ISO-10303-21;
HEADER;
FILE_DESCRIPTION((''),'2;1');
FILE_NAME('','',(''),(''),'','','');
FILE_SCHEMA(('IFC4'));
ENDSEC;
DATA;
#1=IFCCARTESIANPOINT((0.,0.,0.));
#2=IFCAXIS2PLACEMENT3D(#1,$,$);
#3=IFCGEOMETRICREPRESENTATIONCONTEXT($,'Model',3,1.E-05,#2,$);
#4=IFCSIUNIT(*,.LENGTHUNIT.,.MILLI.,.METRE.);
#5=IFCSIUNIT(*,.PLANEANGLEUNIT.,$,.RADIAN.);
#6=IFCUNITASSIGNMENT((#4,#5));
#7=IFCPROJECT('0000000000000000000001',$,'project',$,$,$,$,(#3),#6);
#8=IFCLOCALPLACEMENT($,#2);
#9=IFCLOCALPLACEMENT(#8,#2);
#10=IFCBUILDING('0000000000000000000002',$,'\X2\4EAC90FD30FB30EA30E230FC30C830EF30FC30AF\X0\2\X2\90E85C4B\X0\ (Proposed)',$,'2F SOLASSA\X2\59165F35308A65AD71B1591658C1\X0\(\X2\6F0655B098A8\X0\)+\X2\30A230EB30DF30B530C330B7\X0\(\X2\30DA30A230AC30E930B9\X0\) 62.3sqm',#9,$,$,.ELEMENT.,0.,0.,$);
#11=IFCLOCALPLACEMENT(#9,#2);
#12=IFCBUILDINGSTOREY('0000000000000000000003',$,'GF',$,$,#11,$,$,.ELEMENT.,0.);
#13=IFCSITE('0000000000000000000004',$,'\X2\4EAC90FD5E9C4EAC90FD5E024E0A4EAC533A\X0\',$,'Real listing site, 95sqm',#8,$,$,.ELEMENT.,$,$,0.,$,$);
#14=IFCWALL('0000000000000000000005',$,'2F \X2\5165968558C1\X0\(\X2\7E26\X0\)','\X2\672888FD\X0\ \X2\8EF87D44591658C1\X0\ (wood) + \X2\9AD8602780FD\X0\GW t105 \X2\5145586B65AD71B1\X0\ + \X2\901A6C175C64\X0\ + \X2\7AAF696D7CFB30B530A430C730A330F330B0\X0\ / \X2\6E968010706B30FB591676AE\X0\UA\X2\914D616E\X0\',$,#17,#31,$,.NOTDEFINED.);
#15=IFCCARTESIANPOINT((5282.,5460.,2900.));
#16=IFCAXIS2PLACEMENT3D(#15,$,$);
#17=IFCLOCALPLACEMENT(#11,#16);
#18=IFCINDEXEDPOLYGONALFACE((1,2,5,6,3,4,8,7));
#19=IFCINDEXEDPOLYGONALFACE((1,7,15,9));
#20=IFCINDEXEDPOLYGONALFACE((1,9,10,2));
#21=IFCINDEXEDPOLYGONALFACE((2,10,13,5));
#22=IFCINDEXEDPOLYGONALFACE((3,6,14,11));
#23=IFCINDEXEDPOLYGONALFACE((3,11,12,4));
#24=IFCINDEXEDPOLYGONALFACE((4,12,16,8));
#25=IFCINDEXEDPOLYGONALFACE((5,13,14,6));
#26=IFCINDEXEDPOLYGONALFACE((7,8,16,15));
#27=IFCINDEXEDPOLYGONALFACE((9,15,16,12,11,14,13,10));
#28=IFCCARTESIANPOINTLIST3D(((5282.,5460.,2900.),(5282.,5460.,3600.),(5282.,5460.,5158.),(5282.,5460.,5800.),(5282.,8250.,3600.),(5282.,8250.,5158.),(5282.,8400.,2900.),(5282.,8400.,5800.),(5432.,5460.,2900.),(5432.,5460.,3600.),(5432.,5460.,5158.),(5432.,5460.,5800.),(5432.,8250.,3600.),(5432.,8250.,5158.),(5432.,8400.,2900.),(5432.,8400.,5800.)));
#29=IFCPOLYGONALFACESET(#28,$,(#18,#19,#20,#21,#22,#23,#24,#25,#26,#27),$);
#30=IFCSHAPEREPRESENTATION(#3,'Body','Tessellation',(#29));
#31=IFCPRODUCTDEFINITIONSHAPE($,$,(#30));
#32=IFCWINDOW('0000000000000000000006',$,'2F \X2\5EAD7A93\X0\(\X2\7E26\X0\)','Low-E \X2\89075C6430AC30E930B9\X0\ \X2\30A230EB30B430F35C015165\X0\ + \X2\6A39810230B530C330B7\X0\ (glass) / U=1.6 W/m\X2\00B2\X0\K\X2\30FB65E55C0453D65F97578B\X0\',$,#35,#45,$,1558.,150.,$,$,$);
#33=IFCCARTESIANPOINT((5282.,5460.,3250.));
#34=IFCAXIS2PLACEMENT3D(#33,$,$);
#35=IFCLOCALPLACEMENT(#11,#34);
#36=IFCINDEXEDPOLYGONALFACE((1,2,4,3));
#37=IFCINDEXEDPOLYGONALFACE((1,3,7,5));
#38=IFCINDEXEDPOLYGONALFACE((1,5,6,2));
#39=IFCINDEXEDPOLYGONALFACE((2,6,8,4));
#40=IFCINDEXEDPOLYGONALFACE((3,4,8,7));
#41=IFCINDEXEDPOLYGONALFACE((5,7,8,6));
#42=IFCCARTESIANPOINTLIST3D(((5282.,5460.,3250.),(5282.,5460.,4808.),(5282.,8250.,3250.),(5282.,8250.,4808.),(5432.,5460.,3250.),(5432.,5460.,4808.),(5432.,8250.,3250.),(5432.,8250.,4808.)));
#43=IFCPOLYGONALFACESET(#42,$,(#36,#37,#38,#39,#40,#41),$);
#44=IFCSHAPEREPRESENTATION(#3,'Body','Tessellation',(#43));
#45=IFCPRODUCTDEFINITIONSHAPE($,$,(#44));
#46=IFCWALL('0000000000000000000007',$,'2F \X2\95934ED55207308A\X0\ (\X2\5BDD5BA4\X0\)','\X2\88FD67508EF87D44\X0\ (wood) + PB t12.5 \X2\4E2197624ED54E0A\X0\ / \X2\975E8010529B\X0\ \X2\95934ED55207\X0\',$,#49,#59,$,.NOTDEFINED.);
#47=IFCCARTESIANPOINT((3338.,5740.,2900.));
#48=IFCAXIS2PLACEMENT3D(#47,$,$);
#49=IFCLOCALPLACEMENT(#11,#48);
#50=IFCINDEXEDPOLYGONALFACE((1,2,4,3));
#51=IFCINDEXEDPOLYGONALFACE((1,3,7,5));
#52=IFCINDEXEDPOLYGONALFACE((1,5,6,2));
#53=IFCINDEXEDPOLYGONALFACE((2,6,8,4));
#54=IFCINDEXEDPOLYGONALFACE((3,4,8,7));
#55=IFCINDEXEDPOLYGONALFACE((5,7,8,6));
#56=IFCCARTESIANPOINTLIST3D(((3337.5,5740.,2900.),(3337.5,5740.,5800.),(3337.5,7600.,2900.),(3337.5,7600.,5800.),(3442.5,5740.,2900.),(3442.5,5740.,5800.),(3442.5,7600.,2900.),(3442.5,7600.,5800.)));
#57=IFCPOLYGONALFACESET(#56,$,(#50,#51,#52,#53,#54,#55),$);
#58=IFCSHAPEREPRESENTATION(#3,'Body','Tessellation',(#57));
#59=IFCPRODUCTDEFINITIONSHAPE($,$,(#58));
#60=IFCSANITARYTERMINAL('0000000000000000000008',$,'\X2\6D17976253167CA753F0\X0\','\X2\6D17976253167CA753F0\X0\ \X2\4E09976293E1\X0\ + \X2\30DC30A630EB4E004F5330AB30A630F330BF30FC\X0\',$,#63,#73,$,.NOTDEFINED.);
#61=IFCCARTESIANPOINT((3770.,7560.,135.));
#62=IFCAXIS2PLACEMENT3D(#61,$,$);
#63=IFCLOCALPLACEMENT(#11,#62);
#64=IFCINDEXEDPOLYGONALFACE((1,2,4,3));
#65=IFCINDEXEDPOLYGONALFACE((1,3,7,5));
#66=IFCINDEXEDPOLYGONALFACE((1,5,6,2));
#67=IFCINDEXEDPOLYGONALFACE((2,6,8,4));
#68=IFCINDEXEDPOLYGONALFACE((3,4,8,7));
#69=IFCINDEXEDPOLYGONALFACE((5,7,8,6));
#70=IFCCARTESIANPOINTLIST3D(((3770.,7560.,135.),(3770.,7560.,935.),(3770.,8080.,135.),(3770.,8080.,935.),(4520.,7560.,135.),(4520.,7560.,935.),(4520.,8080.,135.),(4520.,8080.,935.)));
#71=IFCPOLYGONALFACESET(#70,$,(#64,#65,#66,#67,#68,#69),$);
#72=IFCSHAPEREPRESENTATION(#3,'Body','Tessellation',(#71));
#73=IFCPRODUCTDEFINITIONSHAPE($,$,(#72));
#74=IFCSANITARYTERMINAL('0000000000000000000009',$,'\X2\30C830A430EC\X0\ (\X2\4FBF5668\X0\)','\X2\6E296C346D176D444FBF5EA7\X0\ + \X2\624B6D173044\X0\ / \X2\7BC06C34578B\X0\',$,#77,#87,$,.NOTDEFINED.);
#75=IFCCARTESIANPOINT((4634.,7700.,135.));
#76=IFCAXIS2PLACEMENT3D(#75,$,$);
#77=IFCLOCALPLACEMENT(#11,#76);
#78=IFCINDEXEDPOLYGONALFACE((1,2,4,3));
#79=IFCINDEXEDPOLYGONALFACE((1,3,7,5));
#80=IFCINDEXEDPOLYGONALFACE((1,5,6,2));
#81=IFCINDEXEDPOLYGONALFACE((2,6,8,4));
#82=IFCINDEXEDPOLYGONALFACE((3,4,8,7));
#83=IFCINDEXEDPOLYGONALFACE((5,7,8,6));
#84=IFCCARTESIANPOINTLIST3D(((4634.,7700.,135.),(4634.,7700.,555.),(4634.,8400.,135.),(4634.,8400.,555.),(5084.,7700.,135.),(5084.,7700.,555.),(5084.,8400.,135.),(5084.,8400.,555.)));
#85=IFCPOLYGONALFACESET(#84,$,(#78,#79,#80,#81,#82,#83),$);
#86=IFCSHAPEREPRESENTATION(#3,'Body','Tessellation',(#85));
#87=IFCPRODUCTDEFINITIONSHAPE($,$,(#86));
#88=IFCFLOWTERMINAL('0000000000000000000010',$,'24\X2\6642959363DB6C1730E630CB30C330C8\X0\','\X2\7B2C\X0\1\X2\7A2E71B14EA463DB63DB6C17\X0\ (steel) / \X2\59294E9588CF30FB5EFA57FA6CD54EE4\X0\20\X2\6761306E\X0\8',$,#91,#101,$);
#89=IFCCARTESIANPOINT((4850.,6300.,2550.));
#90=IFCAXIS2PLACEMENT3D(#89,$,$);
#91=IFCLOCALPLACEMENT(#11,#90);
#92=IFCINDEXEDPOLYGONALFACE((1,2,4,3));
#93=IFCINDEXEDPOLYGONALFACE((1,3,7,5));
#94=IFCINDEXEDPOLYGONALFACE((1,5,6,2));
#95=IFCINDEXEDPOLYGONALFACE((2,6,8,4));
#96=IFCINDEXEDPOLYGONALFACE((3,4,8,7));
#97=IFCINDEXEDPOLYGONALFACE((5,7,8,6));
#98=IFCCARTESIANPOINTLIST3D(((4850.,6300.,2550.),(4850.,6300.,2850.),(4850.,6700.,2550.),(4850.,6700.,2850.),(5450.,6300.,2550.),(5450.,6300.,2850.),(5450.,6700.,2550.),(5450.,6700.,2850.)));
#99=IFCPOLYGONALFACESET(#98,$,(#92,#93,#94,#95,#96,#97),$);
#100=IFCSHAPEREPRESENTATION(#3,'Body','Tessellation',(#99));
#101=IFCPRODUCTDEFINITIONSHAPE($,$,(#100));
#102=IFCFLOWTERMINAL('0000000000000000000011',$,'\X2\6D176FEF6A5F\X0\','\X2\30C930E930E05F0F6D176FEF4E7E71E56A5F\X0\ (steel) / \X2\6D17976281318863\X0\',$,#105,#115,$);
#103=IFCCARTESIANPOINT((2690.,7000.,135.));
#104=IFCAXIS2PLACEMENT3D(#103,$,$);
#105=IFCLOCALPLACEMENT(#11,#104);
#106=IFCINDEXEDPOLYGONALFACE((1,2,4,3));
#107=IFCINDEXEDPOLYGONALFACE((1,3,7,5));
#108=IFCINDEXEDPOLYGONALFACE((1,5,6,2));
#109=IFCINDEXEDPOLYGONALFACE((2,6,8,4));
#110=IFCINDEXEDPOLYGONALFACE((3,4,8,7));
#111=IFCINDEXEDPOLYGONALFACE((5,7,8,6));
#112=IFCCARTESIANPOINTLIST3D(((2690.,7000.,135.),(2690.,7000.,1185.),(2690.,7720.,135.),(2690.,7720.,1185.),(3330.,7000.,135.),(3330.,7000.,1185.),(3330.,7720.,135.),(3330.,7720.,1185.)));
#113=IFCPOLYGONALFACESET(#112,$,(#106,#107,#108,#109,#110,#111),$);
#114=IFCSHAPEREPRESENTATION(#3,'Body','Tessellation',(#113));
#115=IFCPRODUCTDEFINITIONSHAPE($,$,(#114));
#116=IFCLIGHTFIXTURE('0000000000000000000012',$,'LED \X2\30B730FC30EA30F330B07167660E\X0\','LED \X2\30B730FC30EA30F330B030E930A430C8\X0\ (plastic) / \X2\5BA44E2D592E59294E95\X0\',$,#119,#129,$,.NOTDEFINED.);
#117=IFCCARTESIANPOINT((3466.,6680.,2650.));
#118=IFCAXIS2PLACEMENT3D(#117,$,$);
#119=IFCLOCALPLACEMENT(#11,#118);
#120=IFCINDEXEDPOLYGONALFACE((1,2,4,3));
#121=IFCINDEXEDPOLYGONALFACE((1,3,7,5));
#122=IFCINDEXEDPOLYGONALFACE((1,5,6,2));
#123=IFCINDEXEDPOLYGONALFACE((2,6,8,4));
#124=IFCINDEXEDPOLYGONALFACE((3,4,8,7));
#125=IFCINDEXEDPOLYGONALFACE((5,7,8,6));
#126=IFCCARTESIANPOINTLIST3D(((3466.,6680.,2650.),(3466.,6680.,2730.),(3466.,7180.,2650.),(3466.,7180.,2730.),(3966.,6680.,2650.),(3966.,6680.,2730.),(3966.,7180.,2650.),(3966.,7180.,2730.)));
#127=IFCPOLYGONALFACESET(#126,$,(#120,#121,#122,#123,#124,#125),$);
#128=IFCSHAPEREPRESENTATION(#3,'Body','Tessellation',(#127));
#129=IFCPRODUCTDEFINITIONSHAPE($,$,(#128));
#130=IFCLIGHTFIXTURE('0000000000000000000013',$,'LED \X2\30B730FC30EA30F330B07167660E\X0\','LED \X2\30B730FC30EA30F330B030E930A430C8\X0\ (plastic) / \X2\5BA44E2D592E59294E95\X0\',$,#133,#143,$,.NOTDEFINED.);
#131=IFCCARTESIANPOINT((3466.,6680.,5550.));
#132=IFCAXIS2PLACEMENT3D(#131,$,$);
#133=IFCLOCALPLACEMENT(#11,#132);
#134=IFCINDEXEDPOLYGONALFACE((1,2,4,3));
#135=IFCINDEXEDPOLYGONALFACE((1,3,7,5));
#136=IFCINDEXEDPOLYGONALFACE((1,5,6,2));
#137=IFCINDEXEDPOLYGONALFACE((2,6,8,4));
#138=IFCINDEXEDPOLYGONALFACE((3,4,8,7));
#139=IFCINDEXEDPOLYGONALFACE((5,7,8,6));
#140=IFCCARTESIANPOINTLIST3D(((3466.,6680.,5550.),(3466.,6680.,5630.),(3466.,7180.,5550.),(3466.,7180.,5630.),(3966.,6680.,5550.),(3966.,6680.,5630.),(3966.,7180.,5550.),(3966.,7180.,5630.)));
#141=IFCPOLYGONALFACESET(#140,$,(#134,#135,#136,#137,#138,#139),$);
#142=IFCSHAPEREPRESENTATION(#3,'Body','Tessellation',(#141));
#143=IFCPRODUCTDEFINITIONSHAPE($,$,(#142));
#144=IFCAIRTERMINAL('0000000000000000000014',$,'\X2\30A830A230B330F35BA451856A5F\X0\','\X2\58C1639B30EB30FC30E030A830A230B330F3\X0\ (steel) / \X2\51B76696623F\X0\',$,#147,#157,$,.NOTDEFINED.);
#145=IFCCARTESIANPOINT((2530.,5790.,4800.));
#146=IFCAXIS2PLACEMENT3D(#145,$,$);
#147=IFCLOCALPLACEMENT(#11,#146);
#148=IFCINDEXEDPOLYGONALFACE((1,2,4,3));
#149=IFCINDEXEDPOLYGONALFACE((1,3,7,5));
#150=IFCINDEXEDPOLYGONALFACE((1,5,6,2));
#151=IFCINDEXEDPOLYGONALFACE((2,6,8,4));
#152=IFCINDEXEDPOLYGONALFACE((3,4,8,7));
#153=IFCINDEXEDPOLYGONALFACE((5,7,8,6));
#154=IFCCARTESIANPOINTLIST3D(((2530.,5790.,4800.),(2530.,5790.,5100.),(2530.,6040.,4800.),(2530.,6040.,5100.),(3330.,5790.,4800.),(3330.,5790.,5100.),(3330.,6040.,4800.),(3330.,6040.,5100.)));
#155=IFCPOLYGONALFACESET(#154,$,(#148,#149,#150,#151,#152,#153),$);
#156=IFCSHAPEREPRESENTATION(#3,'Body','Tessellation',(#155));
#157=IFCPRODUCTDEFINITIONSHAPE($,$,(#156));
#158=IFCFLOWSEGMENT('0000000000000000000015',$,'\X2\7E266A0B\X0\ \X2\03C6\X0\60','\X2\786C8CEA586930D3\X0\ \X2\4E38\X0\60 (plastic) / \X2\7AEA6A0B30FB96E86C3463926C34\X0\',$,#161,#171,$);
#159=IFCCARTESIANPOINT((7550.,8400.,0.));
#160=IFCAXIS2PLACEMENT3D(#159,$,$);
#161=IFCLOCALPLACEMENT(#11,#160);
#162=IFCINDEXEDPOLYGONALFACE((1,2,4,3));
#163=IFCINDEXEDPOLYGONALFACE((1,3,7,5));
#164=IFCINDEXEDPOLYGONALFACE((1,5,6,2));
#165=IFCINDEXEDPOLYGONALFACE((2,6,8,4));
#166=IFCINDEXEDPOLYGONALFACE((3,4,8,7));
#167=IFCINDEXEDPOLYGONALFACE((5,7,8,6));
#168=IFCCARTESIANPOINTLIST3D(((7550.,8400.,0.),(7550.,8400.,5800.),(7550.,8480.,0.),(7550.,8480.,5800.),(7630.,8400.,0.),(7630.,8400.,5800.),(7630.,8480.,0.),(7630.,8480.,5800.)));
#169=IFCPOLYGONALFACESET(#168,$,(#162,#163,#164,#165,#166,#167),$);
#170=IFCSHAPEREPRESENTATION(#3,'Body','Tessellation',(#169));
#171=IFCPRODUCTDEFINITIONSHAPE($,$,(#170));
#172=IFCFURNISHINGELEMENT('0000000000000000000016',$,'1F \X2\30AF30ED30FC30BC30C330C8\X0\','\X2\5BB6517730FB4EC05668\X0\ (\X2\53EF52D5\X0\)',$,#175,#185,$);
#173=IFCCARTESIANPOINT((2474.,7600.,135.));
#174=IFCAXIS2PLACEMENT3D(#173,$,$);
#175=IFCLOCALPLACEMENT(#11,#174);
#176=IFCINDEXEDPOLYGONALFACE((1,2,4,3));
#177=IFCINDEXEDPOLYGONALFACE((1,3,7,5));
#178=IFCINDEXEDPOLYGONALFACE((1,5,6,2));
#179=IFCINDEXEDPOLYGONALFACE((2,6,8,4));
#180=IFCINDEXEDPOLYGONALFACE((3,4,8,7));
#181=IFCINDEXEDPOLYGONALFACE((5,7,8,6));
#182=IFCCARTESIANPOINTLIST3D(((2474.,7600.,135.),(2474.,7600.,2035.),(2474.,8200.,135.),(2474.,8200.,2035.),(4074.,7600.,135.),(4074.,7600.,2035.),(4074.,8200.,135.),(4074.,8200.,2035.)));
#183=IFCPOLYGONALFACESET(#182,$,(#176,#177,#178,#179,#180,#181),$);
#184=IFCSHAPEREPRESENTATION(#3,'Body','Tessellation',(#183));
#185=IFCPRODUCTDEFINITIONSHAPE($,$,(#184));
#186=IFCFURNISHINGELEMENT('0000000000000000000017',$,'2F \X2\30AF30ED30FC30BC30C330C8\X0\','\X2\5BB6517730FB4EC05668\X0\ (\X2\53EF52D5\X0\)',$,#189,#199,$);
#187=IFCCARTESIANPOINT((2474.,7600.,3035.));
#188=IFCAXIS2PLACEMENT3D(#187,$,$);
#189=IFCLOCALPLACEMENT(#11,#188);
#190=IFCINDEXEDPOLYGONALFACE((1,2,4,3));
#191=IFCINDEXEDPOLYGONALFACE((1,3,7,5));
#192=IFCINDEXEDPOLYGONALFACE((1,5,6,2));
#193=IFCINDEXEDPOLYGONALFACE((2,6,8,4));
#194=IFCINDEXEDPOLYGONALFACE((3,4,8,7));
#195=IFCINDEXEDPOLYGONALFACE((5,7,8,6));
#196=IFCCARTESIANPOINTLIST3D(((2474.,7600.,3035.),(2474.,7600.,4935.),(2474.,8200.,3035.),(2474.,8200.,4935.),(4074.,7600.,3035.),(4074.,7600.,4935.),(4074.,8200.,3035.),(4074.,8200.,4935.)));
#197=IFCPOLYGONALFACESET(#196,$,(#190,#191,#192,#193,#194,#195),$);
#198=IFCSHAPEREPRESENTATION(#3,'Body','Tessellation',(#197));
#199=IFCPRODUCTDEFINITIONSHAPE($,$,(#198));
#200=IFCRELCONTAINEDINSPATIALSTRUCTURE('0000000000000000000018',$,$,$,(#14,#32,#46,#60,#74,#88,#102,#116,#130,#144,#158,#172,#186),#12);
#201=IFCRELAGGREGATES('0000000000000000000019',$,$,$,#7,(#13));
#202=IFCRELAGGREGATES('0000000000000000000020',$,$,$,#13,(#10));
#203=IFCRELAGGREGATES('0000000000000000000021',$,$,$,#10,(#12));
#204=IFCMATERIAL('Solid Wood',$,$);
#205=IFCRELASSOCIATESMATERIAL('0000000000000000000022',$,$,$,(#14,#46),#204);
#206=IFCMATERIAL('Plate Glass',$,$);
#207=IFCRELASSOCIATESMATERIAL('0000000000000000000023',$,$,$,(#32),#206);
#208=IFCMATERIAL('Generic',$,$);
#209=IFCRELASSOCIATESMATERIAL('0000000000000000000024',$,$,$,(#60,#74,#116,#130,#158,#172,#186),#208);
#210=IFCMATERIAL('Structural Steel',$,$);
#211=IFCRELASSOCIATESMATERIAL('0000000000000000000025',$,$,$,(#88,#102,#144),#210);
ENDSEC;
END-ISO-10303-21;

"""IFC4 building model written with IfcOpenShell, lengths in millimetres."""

from ifc_helpers import new_model, si_unit, frame, frame_2d, origin, place, context, project, spatial, rectangle, extrude, material, element, fill, save


model = new_model("IFC4")

# Units and contexts
model_context = context("Model", 3, precision=1e-05, world=origin())
ifc_project = project(units=[si_unit("LENGTHUNIT", "METRE", prefix="MILLI"), si_unit("PLANEANGLEUNIT", "RADIAN")], contexts=[model_context])

# Site, building, storey
site_placement = place(None, origin())
site = spatial("IfcSite", under=ifc_project, at=site_placement, Name="京都府京都市上京区", ObjectType="Real listing site, 95sqm", CompositionType="ELEMENT", RefElevation=0.0)
building_placement = place(site_placement, origin())
building = spatial("IfcBuilding", under=site, at=building_placement, Name="京都・リモートワーク2部屋 (Proposed)", ObjectType="2F SOLASSA外張り断熱外壁(漆喰風)+アルミサッシ(ペアガラス) 62.3sqm", CompositionType="ELEMENT", ElevationOfRefHeight=0.0, ElevationOfTerrain=0.0)
storey_placement = place(building_placement, origin())
storey = spatial("IfcBuildingStorey", under=building, at=storey_placement, Name="GF", CompositionType="ELEMENT", Elevation=0.0)

# Shared definitions
ifc_material_1 = material(Name="Solid Wood")

# Shared definitions
ifc_material_2 = material(Name="Plate Glass")

# Wall, opening, window
wall_1_placement = place(storey_placement, frame((5282.0, 5460.0, 2900.0)))
wall_1 = element("IfcWall", 1, at=wall_1_placement, inside=storey, material=ifc_material_1, Name="2F 入隅壁(縦)", Description="木製 軸組外壁 (wood) + 高性能GW t105 充填断熱 + 通気層 + 窯業系サイディング / 準耐火・外皮UA配慮", PredefinedType="NOTDEFINED", context=model_context, shape_type="SweptSolid", body=[
    extrude(rectangle(XDim=150.0, YDim=2940.0, at=frame_2d((75.0, 1470.0))), frame((5282.0, 5460.0, 2900.0)), (0.0, 0.0, 1.0), 2900.0),
])
opening_1_placement = place(storey_placement, frame((5282.0, 5460.0, 3250.0)))
opening_1 = element("IfcOpeningElement", 2, at=opening_1_placement, cuts=wall_1, PredefinedType="NOTDEFINED", context=model_context, shape_type="SweptSolid", body=[
    extrude(rectangle(XDim=150.0, YDim=2790.0, at=frame_2d((75.0, 1395.0))), frame((5282.0, 5460.0, 3250.0)), (0.0, 0.0, 1.0), 1558.0),
])
window_1_placement = place(storey_placement, frame((5282.0, 5460.0, 3250.0)))
window_1 = element("IfcWindow", 3, at=window_1_placement, inside=storey, material=ifc_material_2, Name="2F 庭窓(縦)", Description="Low-E 複層ガラス アルゴン封入 + 樹脂サッシ (glass) / U=1.6 W/m²K・日射取得型", OverallHeight=1558.0, OverallWidth=150.0, context=model_context, shape_type="SweptSolid", body=[
    extrude(rectangle(XDim=150.0, YDim=2790.0, at=frame_2d((75.0, 1395.0))), frame((5282.0, 5460.0, 3250.0)), (0.0, 0.0, 1.0), 1558.0),
])
fill(opening_1, window_1)

# Wall
wall_2_placement = place(storey_placement, frame((3338.0, 5740.0, 2900.0)))
element("IfcWall", 4, at=wall_2_placement, inside=storey, material=ifc_material_1, Name="2F 間仕切り (寝室)", Description="製材軸組 (wood) + PB t12.5 両面仕上 / 非耐力 間仕切", PredefinedType="NOTDEFINED", context=model_context, shape_type="SweptSolid", body=[
    extrude(rectangle(XDim=105.0, YDim=1860.0, at=frame_2d((52.0, 930.0))), frame((3338.0, 5740.0, 2900.0)), (0.0, 0.0, 1.0), 2900.0),
])

# Sanitary terminals
ifc_material_3 = material(Name="Generic")
sanitary_terminal_1_placement = place(storey_placement, frame((3770.0, 7560.0, 135.0)))
element("IfcSanitaryTerminal", 5, at=sanitary_terminal_1_placement, inside=storey, material=ifc_material_3, Name="洗面化粧台", Description="洗面化粧台 三面鏡 + ボウル一体カウンター", PredefinedType="NOTDEFINED", context=model_context, shape_type="SweptSolid", body=[
    extrude(rectangle(XDim=750.0, YDim=520.0, at=frame_2d((375.0, 260.0))), frame((3770.0, 7560.0, 135.0)), (0.0, 0.0, 1.0), 800.0),
])
sanitary_terminal_2_placement = place(storey_placement, frame((4634.0, 7700.0, 135.0)))
element("IfcSanitaryTerminal", 6, at=sanitary_terminal_2_placement, inside=storey, material=ifc_material_3, Name="トイレ (便器)", Description="温水洗浄便座 + 手洗い / 節水型", PredefinedType="NOTDEFINED", context=model_context, shape_type="SweptSolid", body=[
    extrude(rectangle(XDim=450.0, YDim=700.0, at=frame_2d((225.0, 350.0))), frame((4634.0, 7700.0, 135.0)), (0.0, 0.0, 1.0), 420.0),
])

# Flow terminals
ifc_material_4 = material(Name="Structural Steel")
flow_terminal_1_placement = place(storey_placement, frame((4850.0, 6300.0, 2550.0)))
element("IfcFlowTerminal", 7, at=flow_terminal_1_placement, inside=storey, material=ifc_material_4, Name="24時間換気ユニット", Description="第1種熱交換換気 (steel) / 天井裏・建基法令20条の8", context=model_context, shape_type="SweptSolid", body=[
    extrude(rectangle(XDim=600.0, YDim=400.0, at=frame_2d((300.0, 200.0))), frame((4850.0, 6300.0, 2550.0)), (0.0, 0.0, 1.0), 300.0),
])
flow_terminal_2_placement = place(storey_placement, frame((2690.0, 7000.0, 135.0)))
element("IfcFlowTerminal", 8, at=flow_terminal_2_placement, inside=storey, material=ifc_material_4, Name="洗濯機", Description="ドラム式洗濯乾燥機 (steel) / 洗面脱衣", context=model_context, shape_type="SweptSolid", body=[
    extrude(rectangle(XDim=640.0, YDim=720.0, at=frame_2d((320.0, 360.0))), frame((2690.0, 7000.0, 135.0)), (0.0, 0.0, 1.0), 1050.0),
])

# Light fixtures
light_fixture_1_placement = place(storey_placement, frame((3466.0, 6680.0, 2650.0)))
element("IfcLightFixture", 9, at=light_fixture_1_placement, inside=storey, material=ifc_material_3, Name="LED シーリング照明", Description="LED シーリングライト (plastic) / 室中央天井", PredefinedType="NOTDEFINED", context=model_context, shape_type="SweptSolid", body=[
    extrude(rectangle(XDim=500.0, YDim=500.0, at=frame_2d((250.0, 250.0))), frame((3466.0, 6680.0, 2650.0)), (0.0, 0.0, 1.0), 80.0),
])
light_fixture_2_placement = place(storey_placement, frame((3466.0, 6680.0, 5550.0)))
element("IfcLightFixture", 10, at=light_fixture_2_placement, inside=storey, material=ifc_material_3, Name="LED シーリング照明", Description="LED シーリングライト (plastic) / 室中央天井", PredefinedType="NOTDEFINED", context=model_context, shape_type="SweptSolid", body=[
    extrude(rectangle(XDim=500.0, YDim=500.0, at=frame_2d((250.0, 250.0))), frame((3466.0, 6680.0, 5550.0)), (0.0, 0.0, 1.0), 80.0),
])

# Air terminal
air_terminal_placement = place(storey_placement, frame((2530.0, 5790.0, 4800.0)))
element("IfcAirTerminal", 11, at=air_terminal_placement, inside=storey, material=ifc_material_4, Name="エアコン室内機", Description="壁掛ルームエアコン (steel) / 冷暖房", PredefinedType="NOTDEFINED", context=model_context, shape_type="SweptSolid", body=[
    extrude(rectangle(XDim=800.0, YDim=250.0, at=frame_2d((400.0, 125.0))), frame((2530.0, 5790.0, 4800.0)), (0.0, 0.0, 1.0), 300.0),
])

# Flow segment
flow_segment_placement = place(storey_placement, frame((7550.0, 8400.0, 0.0)))
element("IfcFlowSegment", 12, at=flow_segment_placement, inside=storey, material=ifc_material_3, Name="縦樋 φ60", Description="硬質塩ビ 丸60 (plastic) / 竪樋・雨水排水", context=model_context, shape_type="SweptSolid", body=[
    extrude(rectangle(XDim=80.0, YDim=80.0, at=frame_2d((40.0, 40.0))), frame((7550.0, 8400.0, 0.0)), (0.0, 0.0, 1.0), 5800.0),
])

# Furnishing elements
furnishing_1_placement = place(storey_placement, frame((2474.0, 7600.0, 135.0)))
element("IfcFurnishingElement", 13, at=furnishing_1_placement, inside=storey, material=ifc_material_3, Name="1F クローゼット", Description="家具・什器 (可動)", context=model_context, shape_type="SweptSolid", body=[
    extrude(rectangle(XDim=1600.0, YDim=600.0, at=frame_2d((800.0, 300.0))), frame((2474.0, 7600.0, 135.0)), (0.0, 0.0, 1.0), 1900.0),
])
furnishing_2_placement = place(storey_placement, frame((2474.0, 7600.0, 3035.0)))
element("IfcFurnishingElement", 14, at=furnishing_2_placement, inside=storey, material=ifc_material_3, Name="2F クローゼット", Description="家具・什器 (可動)", context=model_context, shape_type="SweptSolid", body=[
    extrude(rectangle(XDim=1600.0, YDim=600.0, at=frame_2d((800.0, 300.0))), frame((2474.0, 7600.0, 3035.0)), (0.0, 0.0, 1.0), 1900.0),
])

save(model, "model.ifc")
